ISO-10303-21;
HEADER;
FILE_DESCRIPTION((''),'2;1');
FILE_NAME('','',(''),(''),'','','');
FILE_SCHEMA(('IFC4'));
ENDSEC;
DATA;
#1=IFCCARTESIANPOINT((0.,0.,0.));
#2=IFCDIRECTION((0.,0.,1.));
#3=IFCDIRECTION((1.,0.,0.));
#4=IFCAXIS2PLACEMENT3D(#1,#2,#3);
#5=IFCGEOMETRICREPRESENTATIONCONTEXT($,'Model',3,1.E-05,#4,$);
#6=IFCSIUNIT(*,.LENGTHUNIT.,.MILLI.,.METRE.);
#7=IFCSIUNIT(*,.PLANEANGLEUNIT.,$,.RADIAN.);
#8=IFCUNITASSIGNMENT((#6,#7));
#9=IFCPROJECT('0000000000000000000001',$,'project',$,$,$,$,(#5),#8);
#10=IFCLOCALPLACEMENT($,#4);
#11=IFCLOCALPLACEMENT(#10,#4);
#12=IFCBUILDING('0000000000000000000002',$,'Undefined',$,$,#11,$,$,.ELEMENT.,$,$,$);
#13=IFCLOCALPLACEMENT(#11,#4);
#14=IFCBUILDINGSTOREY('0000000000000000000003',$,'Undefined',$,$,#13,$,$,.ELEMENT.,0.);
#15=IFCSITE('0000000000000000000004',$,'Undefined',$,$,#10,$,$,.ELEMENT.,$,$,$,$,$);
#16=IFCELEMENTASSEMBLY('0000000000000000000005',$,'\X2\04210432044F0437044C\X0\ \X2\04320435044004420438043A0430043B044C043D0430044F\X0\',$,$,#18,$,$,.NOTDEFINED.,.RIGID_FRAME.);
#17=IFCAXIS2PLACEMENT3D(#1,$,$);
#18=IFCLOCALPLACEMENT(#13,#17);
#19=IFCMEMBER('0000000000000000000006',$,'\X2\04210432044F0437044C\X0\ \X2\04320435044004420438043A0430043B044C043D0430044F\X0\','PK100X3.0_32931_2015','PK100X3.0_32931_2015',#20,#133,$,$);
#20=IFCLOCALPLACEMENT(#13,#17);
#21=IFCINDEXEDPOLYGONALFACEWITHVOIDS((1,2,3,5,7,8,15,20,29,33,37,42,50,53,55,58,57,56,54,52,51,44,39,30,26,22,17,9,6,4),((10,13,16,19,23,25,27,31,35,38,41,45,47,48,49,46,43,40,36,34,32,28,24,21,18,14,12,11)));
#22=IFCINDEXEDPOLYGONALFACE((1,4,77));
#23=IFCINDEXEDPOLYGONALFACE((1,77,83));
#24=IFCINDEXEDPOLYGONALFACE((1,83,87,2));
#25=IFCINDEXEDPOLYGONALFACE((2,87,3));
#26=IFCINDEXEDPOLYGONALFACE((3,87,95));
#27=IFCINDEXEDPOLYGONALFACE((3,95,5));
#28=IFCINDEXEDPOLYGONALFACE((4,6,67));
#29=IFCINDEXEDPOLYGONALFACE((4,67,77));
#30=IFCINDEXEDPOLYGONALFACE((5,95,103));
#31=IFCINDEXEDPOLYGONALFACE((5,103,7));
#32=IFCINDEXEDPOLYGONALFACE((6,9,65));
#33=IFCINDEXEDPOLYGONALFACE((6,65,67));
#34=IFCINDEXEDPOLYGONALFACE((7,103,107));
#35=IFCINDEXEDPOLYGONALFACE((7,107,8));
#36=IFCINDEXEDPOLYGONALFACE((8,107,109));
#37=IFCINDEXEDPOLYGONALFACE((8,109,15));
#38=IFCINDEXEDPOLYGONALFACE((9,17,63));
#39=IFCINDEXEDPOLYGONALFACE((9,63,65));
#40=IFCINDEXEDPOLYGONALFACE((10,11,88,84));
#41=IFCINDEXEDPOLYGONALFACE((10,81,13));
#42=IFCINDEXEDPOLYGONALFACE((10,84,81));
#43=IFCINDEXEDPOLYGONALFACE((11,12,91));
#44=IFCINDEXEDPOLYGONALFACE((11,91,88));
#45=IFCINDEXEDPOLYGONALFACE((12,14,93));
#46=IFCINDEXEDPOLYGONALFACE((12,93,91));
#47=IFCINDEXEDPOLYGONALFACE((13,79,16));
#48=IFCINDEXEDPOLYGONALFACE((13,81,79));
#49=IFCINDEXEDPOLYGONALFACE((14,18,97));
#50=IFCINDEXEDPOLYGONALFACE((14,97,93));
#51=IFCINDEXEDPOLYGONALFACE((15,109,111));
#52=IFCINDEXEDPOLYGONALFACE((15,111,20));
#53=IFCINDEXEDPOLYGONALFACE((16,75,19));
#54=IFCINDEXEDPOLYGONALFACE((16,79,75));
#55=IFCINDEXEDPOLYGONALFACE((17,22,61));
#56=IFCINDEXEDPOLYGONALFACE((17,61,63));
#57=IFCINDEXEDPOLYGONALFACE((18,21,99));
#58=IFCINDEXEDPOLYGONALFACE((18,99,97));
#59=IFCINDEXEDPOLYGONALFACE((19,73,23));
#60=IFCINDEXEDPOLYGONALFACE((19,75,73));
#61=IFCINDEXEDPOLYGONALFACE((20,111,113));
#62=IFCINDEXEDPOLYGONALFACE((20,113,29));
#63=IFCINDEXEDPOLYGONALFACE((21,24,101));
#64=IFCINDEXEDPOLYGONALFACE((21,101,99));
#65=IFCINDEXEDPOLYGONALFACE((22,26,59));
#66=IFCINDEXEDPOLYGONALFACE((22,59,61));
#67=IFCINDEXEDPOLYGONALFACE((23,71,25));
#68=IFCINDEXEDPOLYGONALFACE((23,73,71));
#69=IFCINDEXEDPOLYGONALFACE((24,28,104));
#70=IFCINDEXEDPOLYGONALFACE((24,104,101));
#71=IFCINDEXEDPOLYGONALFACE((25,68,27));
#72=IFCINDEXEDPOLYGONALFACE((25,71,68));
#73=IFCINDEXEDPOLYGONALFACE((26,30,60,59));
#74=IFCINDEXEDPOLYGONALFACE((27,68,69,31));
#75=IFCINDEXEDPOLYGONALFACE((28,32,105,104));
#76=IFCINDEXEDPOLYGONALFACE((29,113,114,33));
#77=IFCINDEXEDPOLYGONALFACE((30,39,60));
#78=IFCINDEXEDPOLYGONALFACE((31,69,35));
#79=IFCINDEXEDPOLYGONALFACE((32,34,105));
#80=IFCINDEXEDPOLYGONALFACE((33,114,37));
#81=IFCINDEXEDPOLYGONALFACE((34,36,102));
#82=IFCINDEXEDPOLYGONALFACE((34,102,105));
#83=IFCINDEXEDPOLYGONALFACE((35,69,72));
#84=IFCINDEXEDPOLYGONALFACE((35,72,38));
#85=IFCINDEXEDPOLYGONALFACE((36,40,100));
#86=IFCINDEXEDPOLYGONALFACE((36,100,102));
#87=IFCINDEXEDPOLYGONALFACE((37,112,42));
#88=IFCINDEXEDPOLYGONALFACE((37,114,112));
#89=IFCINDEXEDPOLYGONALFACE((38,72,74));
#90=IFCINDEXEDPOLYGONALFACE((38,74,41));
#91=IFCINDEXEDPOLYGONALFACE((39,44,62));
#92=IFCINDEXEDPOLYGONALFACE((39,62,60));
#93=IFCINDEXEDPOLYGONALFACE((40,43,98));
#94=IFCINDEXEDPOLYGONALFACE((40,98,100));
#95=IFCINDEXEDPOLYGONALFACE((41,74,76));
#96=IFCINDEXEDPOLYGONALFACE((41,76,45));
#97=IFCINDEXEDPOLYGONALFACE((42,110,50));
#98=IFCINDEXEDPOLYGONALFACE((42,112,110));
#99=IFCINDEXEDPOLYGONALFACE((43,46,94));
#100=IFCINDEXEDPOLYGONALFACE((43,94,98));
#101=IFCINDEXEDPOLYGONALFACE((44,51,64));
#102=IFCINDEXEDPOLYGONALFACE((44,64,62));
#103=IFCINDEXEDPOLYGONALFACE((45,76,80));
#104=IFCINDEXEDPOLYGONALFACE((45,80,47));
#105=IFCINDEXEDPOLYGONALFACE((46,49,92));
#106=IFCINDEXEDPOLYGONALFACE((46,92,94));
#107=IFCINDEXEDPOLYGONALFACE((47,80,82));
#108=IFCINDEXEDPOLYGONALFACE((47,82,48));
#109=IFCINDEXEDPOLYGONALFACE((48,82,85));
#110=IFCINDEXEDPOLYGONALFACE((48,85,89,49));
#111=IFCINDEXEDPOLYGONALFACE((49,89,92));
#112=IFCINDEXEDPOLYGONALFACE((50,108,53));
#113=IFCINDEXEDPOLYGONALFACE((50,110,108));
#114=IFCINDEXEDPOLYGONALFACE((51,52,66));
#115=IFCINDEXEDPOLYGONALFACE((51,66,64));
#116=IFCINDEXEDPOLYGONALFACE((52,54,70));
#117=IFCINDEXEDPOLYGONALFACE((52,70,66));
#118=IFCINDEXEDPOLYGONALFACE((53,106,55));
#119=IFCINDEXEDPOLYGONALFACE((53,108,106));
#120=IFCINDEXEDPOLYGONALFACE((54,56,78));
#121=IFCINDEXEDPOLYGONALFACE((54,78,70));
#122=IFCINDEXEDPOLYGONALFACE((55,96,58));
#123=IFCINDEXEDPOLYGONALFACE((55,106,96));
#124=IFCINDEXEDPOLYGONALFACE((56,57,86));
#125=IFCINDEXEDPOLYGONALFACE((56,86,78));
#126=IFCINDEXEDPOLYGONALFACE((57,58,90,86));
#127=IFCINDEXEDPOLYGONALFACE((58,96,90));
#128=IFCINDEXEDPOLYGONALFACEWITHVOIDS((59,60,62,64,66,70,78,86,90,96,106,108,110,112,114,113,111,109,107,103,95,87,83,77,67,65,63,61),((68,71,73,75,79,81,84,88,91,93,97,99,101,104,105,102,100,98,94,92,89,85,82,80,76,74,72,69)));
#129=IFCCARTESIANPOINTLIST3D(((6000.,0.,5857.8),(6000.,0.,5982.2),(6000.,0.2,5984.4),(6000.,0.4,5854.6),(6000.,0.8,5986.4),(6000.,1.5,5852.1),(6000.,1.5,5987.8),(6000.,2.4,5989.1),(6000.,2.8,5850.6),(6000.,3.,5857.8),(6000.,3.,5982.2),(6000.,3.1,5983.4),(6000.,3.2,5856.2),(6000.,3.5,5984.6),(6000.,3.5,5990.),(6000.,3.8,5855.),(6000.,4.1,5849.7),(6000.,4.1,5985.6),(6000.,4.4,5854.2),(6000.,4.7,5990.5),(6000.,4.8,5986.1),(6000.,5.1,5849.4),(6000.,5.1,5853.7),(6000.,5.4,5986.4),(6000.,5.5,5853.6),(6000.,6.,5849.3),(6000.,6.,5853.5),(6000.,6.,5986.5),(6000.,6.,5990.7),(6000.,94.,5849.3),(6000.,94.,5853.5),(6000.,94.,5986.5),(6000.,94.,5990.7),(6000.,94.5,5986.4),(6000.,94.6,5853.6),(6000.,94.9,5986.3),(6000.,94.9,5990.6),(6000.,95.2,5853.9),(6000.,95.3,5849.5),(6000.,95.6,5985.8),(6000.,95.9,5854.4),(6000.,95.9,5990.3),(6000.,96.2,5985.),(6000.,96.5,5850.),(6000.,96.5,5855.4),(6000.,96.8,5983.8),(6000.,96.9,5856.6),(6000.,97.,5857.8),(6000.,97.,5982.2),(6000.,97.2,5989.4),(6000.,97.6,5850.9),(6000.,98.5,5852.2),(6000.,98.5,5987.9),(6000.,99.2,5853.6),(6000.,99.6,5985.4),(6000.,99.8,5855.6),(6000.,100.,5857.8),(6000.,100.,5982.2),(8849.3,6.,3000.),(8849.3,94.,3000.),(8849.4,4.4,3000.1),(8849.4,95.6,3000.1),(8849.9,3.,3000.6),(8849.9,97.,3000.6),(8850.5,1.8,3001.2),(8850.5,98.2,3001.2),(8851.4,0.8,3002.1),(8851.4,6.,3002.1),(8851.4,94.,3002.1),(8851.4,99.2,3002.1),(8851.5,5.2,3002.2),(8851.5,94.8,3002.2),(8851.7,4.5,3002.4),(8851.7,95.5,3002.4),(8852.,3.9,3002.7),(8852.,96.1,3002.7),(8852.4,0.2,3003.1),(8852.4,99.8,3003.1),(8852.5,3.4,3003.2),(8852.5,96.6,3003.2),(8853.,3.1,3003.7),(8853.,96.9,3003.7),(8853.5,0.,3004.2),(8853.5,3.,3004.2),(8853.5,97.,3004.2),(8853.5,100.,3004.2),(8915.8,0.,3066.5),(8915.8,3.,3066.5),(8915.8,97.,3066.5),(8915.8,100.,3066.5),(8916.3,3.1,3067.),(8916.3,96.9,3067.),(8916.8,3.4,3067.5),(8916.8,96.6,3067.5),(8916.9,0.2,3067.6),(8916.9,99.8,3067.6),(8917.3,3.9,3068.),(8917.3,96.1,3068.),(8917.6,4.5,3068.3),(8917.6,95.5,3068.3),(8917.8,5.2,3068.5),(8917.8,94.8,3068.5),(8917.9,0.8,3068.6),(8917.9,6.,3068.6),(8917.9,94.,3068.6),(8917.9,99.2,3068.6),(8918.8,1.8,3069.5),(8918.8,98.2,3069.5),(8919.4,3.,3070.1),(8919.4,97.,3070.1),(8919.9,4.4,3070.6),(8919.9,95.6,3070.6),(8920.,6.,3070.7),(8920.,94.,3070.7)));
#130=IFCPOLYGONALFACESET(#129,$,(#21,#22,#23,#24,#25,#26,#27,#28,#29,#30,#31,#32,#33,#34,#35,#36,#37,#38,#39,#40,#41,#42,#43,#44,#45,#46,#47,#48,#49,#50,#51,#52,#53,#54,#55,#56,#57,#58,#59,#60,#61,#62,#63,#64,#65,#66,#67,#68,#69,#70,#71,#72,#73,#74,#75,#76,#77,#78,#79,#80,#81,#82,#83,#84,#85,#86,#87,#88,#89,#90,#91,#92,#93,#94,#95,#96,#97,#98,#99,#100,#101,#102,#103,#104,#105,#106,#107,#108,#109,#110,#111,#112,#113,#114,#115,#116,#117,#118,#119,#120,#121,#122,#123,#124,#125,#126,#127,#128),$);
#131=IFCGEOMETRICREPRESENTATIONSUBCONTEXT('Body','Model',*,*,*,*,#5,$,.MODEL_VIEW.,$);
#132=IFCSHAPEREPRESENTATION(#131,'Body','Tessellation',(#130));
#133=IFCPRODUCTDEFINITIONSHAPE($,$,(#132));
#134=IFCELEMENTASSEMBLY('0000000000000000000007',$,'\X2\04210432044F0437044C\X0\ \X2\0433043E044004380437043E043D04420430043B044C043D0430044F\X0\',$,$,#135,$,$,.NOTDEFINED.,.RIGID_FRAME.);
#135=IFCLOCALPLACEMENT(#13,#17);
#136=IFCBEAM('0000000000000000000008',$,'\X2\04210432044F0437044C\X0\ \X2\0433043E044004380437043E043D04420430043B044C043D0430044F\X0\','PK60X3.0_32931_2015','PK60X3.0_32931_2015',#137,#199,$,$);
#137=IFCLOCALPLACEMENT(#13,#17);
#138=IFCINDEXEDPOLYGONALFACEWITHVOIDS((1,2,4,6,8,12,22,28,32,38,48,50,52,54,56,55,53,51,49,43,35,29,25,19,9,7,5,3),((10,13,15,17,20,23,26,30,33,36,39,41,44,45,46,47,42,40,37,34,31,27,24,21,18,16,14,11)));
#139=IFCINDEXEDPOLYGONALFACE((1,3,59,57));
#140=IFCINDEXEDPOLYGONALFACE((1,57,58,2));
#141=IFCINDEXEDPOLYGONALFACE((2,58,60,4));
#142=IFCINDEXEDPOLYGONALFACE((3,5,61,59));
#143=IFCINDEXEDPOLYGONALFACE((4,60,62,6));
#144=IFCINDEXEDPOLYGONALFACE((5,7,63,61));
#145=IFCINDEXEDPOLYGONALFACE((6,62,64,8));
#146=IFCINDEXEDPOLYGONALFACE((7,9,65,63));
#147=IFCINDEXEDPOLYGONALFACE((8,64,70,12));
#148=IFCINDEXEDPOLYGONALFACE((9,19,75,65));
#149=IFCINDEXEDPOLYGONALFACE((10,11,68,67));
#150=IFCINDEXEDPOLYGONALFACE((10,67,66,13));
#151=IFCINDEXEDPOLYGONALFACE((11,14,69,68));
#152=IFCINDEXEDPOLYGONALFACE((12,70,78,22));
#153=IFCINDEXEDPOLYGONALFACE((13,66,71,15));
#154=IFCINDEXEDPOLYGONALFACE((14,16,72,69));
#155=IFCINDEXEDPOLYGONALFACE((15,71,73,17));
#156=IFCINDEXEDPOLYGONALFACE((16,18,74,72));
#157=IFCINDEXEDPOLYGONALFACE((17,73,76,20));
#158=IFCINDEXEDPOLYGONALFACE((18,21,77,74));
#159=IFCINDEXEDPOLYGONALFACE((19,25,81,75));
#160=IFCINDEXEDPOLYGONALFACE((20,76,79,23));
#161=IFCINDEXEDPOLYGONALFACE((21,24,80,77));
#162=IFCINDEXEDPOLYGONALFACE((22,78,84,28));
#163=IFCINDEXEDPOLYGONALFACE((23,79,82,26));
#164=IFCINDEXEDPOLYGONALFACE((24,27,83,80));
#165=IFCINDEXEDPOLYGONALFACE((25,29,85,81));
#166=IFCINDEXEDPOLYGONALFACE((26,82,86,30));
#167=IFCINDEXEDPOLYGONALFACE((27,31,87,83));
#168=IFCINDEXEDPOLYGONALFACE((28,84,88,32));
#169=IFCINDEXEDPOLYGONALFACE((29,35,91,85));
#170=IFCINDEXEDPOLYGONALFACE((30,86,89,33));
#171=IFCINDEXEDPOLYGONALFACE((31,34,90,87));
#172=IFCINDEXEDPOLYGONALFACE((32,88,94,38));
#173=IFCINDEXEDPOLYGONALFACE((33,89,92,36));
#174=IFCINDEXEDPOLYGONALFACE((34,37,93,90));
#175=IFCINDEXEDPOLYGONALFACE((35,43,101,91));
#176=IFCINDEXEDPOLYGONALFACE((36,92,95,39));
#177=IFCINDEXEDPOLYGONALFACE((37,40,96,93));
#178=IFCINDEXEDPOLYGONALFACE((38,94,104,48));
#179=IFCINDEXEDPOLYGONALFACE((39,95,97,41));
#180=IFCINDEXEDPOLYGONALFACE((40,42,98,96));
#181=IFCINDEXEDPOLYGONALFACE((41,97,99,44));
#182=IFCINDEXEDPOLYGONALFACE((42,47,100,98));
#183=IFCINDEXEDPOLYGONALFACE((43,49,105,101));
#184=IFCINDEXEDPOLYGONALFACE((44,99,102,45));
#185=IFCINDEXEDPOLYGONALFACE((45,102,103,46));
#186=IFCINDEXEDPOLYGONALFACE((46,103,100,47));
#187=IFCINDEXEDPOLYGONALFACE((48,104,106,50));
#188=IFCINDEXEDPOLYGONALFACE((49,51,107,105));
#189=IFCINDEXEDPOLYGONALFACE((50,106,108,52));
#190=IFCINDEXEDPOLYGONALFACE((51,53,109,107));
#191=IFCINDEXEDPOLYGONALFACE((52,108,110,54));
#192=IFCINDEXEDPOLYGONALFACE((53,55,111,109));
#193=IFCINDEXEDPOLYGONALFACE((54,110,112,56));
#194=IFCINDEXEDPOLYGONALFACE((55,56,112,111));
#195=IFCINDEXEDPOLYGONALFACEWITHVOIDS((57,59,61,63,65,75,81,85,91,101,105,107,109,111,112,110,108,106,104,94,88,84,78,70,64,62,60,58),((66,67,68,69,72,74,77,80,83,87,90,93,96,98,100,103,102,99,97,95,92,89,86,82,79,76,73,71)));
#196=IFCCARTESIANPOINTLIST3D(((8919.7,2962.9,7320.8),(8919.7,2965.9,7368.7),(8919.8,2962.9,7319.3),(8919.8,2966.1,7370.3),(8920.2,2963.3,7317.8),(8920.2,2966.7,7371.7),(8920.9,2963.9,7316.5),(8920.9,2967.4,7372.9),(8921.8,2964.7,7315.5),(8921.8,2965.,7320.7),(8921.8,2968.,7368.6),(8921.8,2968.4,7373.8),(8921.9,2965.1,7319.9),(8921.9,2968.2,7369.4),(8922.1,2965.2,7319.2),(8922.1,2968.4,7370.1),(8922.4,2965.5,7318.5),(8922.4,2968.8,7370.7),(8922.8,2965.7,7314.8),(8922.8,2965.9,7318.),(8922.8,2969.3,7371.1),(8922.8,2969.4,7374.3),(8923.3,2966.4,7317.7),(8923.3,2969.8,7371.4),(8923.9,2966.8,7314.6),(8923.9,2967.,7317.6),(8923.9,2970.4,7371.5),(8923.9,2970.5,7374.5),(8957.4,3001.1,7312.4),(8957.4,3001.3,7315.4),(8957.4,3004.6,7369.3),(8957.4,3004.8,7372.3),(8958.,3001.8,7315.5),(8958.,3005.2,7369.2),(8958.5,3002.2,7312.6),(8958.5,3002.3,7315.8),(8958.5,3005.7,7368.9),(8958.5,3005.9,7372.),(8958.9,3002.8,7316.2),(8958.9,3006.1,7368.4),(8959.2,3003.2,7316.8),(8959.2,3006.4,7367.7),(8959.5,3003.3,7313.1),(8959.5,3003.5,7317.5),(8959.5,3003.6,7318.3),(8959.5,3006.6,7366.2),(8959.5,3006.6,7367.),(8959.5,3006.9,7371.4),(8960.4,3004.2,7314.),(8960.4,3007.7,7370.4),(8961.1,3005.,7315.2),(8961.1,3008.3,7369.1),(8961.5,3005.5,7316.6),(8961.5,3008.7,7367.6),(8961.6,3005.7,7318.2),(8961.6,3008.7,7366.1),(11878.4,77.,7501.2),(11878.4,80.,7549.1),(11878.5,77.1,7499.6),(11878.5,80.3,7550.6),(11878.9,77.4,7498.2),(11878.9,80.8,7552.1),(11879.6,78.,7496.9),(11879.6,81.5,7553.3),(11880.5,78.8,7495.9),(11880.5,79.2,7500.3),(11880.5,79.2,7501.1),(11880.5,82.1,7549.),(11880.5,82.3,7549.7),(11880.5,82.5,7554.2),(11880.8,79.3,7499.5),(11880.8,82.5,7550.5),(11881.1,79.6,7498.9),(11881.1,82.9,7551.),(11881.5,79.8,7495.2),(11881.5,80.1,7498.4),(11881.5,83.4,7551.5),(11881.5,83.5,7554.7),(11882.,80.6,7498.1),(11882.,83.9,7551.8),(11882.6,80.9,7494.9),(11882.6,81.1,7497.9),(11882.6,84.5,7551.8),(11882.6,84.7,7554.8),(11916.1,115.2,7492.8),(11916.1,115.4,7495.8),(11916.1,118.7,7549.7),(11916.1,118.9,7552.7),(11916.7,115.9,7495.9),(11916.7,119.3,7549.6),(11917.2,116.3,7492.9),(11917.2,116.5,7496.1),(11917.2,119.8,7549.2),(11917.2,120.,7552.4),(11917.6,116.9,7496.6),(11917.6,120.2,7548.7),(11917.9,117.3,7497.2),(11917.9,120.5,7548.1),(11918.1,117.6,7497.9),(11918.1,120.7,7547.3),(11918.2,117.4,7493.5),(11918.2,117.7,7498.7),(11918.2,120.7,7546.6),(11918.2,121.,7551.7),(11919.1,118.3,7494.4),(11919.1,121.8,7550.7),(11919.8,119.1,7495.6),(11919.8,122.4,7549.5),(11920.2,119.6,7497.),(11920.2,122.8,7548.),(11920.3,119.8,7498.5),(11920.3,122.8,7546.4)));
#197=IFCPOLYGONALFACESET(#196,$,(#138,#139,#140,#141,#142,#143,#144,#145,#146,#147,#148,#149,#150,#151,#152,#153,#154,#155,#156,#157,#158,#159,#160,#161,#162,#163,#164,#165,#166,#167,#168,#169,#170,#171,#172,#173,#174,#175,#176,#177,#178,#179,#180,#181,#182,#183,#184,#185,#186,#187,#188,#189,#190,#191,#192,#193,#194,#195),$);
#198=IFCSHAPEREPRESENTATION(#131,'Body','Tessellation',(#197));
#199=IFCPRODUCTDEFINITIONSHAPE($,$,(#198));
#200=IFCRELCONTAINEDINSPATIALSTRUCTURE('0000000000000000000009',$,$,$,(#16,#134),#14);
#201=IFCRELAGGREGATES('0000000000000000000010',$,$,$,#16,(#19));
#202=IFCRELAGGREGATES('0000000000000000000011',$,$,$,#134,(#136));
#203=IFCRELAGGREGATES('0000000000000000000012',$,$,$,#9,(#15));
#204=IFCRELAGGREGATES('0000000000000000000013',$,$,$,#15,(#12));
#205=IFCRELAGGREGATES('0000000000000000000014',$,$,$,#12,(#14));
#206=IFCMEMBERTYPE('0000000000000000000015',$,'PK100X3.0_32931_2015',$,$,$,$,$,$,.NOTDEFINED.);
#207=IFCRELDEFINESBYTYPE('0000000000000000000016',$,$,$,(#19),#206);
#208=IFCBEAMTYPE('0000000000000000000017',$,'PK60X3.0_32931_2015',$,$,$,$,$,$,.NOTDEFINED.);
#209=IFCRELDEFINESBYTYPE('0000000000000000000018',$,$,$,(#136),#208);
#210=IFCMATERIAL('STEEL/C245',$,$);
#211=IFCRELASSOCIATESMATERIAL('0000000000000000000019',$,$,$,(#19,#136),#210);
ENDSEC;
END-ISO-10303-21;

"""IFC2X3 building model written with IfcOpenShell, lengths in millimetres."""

from ifc_helpers import new_model, si_unit, frame, origin_with_axes, origin_2d_with_axis, place, context, subcontext, project, spatial, hollow_rectangle, extrude, clip, halfspace, material, type_object, element, aggregate, save


model = new_model("IFC2X3")

# Units and contexts
model_context = context("Model", 3, precision=1e-05, world=origin_with_axes())
body_context = subcontext(model_context, "Body", "Model", "MODEL_VIEW")
ifc_project = project(units=[si_unit("LENGTHUNIT", "METRE", prefix="MILLI"), si_unit("PLANEANGLEUNIT", "RADIAN")], contexts=[model_context])

# Site, building, storey
site_placement = place(None, origin_with_axes())
site = spatial("IfcSite", under=ifc_project, at=site_placement, Name="Undefined", CompositionType="ELEMENT")
building_placement = place(site_placement, origin_with_axes())
building = spatial("IfcBuilding", under=site, at=building_placement, Name="Undefined", CompositionType="ELEMENT")
storey_placement = place(building_placement, origin_with_axes())
storey = spatial("IfcBuildingStorey", under=building, at=storey_placement, Name="Undefined", CompositionType="ELEMENT", Elevation=0.0)

# Shared definitions
ifc_material = material(Name="STEEL/C245")

# Element assembly, member
assembly_1_placement = place(storey_placement, origin_with_axes())
assembly_1 = element("IfcElementAssembly", 1, at=assembly_1_placement, inside=storey, Name="Связь вертикальная", AssemblyPlace="NOTDEFINED", PredefinedType="RIGID_FRAME")
member_type_1 = type_object("IfcMemberType", Name="PK100X3.0_32931_2015", PredefinedType="NOTDEFINED")
member_1_placement = place(assembly_1_placement, frame((8920.0, 50.0, 3000.0), z_axis=(0.707107, 0.0, 0.707107), x_axis=(-0.707107, 0.0, 0.707107)))
member_1 = element("IfcMember", 2, at=member_1_placement, type_object=member_type_1, material=ifc_material, Name="Связь вертикальная", Description="PK100X3.0_32931_2015", ObjectType="PK100X3.0_32931_2015", context=body_context, shape_type="Clipping", body=[
    clip(clip(extrude(hollow_rectangle(XDim=100.0, YDim=100.0, WallThickness=3.0, InnerFilletRadius=3.0, OuterFilletRadius=6.0, at=origin_2d_with_axis()), frame((4230.5, 0.0, 0.0), z_axis=(-1.0, 0.0, 0.0), x_axis=(0.0, -1.0, 0.0)), (0.0, 0.0, 1.0), 4281.5), halfspace(frame((3995.7, 50.0, -133.8), z_axis=(-0.707107, 0.0, 0.707107), x_axis=(-0.707107, 0.0, -0.707107)), True)), halfspace(frame((50.0, 50.0, -176.9), z_axis=(-1.0, 0.0, 0.0), x_axis=(0.0, 1.0, 0.0)), False)),
])
aggregate(assembly_1, [member_1])

# Element assembly, beam
assembly_2_placement = place(storey_placement, origin_with_axes())
assembly_2 = element("IfcElementAssembly", 3, at=assembly_2_placement, inside=storey, Name="Связь горизонтальная", AssemblyPlace="NOTDEFINED", PredefinedType="RIGID_FRAME")
beam_type_1 = type_object("IfcBeamType", Name="PK60X3.0_32931_2015", PredefinedType="NOTDEFINED")
beam_1_placement = place(assembly_2_placement, frame((11899.3, 99.9, 7523.8), z_axis=(0.0, 0.062378, 0.998053), x_axis=(-0.715179, 0.69758, -0.043599)))
beam_1 = element("IfcBeam", 4, at=beam_1_placement, type_object=beam_type_1, material=ifc_material, Name="Связь горизонтальная", Description="PK60X3.0_32931_2015", ObjectType="PK60X3.0_32931_2015", context=body_context, shape_type="SweptSolid", body=[
    extrude(hollow_rectangle(XDim=60.0, YDim=60.0, WallThickness=3.0, InnerFilletRadius=3.0, OuterFilletRadius=6.0, at=origin_2d_with_axis()), frame((4137.0, 0.0, 0.0), z_axis=(-1.0, 0.0, 0.0), x_axis=(0.0, -1.0, 0.0)), (0.0, 0.0, 1.0), 4137.0),
])
aggregate(assembly_2, [beam_1])

save(model, "model.ifc")
